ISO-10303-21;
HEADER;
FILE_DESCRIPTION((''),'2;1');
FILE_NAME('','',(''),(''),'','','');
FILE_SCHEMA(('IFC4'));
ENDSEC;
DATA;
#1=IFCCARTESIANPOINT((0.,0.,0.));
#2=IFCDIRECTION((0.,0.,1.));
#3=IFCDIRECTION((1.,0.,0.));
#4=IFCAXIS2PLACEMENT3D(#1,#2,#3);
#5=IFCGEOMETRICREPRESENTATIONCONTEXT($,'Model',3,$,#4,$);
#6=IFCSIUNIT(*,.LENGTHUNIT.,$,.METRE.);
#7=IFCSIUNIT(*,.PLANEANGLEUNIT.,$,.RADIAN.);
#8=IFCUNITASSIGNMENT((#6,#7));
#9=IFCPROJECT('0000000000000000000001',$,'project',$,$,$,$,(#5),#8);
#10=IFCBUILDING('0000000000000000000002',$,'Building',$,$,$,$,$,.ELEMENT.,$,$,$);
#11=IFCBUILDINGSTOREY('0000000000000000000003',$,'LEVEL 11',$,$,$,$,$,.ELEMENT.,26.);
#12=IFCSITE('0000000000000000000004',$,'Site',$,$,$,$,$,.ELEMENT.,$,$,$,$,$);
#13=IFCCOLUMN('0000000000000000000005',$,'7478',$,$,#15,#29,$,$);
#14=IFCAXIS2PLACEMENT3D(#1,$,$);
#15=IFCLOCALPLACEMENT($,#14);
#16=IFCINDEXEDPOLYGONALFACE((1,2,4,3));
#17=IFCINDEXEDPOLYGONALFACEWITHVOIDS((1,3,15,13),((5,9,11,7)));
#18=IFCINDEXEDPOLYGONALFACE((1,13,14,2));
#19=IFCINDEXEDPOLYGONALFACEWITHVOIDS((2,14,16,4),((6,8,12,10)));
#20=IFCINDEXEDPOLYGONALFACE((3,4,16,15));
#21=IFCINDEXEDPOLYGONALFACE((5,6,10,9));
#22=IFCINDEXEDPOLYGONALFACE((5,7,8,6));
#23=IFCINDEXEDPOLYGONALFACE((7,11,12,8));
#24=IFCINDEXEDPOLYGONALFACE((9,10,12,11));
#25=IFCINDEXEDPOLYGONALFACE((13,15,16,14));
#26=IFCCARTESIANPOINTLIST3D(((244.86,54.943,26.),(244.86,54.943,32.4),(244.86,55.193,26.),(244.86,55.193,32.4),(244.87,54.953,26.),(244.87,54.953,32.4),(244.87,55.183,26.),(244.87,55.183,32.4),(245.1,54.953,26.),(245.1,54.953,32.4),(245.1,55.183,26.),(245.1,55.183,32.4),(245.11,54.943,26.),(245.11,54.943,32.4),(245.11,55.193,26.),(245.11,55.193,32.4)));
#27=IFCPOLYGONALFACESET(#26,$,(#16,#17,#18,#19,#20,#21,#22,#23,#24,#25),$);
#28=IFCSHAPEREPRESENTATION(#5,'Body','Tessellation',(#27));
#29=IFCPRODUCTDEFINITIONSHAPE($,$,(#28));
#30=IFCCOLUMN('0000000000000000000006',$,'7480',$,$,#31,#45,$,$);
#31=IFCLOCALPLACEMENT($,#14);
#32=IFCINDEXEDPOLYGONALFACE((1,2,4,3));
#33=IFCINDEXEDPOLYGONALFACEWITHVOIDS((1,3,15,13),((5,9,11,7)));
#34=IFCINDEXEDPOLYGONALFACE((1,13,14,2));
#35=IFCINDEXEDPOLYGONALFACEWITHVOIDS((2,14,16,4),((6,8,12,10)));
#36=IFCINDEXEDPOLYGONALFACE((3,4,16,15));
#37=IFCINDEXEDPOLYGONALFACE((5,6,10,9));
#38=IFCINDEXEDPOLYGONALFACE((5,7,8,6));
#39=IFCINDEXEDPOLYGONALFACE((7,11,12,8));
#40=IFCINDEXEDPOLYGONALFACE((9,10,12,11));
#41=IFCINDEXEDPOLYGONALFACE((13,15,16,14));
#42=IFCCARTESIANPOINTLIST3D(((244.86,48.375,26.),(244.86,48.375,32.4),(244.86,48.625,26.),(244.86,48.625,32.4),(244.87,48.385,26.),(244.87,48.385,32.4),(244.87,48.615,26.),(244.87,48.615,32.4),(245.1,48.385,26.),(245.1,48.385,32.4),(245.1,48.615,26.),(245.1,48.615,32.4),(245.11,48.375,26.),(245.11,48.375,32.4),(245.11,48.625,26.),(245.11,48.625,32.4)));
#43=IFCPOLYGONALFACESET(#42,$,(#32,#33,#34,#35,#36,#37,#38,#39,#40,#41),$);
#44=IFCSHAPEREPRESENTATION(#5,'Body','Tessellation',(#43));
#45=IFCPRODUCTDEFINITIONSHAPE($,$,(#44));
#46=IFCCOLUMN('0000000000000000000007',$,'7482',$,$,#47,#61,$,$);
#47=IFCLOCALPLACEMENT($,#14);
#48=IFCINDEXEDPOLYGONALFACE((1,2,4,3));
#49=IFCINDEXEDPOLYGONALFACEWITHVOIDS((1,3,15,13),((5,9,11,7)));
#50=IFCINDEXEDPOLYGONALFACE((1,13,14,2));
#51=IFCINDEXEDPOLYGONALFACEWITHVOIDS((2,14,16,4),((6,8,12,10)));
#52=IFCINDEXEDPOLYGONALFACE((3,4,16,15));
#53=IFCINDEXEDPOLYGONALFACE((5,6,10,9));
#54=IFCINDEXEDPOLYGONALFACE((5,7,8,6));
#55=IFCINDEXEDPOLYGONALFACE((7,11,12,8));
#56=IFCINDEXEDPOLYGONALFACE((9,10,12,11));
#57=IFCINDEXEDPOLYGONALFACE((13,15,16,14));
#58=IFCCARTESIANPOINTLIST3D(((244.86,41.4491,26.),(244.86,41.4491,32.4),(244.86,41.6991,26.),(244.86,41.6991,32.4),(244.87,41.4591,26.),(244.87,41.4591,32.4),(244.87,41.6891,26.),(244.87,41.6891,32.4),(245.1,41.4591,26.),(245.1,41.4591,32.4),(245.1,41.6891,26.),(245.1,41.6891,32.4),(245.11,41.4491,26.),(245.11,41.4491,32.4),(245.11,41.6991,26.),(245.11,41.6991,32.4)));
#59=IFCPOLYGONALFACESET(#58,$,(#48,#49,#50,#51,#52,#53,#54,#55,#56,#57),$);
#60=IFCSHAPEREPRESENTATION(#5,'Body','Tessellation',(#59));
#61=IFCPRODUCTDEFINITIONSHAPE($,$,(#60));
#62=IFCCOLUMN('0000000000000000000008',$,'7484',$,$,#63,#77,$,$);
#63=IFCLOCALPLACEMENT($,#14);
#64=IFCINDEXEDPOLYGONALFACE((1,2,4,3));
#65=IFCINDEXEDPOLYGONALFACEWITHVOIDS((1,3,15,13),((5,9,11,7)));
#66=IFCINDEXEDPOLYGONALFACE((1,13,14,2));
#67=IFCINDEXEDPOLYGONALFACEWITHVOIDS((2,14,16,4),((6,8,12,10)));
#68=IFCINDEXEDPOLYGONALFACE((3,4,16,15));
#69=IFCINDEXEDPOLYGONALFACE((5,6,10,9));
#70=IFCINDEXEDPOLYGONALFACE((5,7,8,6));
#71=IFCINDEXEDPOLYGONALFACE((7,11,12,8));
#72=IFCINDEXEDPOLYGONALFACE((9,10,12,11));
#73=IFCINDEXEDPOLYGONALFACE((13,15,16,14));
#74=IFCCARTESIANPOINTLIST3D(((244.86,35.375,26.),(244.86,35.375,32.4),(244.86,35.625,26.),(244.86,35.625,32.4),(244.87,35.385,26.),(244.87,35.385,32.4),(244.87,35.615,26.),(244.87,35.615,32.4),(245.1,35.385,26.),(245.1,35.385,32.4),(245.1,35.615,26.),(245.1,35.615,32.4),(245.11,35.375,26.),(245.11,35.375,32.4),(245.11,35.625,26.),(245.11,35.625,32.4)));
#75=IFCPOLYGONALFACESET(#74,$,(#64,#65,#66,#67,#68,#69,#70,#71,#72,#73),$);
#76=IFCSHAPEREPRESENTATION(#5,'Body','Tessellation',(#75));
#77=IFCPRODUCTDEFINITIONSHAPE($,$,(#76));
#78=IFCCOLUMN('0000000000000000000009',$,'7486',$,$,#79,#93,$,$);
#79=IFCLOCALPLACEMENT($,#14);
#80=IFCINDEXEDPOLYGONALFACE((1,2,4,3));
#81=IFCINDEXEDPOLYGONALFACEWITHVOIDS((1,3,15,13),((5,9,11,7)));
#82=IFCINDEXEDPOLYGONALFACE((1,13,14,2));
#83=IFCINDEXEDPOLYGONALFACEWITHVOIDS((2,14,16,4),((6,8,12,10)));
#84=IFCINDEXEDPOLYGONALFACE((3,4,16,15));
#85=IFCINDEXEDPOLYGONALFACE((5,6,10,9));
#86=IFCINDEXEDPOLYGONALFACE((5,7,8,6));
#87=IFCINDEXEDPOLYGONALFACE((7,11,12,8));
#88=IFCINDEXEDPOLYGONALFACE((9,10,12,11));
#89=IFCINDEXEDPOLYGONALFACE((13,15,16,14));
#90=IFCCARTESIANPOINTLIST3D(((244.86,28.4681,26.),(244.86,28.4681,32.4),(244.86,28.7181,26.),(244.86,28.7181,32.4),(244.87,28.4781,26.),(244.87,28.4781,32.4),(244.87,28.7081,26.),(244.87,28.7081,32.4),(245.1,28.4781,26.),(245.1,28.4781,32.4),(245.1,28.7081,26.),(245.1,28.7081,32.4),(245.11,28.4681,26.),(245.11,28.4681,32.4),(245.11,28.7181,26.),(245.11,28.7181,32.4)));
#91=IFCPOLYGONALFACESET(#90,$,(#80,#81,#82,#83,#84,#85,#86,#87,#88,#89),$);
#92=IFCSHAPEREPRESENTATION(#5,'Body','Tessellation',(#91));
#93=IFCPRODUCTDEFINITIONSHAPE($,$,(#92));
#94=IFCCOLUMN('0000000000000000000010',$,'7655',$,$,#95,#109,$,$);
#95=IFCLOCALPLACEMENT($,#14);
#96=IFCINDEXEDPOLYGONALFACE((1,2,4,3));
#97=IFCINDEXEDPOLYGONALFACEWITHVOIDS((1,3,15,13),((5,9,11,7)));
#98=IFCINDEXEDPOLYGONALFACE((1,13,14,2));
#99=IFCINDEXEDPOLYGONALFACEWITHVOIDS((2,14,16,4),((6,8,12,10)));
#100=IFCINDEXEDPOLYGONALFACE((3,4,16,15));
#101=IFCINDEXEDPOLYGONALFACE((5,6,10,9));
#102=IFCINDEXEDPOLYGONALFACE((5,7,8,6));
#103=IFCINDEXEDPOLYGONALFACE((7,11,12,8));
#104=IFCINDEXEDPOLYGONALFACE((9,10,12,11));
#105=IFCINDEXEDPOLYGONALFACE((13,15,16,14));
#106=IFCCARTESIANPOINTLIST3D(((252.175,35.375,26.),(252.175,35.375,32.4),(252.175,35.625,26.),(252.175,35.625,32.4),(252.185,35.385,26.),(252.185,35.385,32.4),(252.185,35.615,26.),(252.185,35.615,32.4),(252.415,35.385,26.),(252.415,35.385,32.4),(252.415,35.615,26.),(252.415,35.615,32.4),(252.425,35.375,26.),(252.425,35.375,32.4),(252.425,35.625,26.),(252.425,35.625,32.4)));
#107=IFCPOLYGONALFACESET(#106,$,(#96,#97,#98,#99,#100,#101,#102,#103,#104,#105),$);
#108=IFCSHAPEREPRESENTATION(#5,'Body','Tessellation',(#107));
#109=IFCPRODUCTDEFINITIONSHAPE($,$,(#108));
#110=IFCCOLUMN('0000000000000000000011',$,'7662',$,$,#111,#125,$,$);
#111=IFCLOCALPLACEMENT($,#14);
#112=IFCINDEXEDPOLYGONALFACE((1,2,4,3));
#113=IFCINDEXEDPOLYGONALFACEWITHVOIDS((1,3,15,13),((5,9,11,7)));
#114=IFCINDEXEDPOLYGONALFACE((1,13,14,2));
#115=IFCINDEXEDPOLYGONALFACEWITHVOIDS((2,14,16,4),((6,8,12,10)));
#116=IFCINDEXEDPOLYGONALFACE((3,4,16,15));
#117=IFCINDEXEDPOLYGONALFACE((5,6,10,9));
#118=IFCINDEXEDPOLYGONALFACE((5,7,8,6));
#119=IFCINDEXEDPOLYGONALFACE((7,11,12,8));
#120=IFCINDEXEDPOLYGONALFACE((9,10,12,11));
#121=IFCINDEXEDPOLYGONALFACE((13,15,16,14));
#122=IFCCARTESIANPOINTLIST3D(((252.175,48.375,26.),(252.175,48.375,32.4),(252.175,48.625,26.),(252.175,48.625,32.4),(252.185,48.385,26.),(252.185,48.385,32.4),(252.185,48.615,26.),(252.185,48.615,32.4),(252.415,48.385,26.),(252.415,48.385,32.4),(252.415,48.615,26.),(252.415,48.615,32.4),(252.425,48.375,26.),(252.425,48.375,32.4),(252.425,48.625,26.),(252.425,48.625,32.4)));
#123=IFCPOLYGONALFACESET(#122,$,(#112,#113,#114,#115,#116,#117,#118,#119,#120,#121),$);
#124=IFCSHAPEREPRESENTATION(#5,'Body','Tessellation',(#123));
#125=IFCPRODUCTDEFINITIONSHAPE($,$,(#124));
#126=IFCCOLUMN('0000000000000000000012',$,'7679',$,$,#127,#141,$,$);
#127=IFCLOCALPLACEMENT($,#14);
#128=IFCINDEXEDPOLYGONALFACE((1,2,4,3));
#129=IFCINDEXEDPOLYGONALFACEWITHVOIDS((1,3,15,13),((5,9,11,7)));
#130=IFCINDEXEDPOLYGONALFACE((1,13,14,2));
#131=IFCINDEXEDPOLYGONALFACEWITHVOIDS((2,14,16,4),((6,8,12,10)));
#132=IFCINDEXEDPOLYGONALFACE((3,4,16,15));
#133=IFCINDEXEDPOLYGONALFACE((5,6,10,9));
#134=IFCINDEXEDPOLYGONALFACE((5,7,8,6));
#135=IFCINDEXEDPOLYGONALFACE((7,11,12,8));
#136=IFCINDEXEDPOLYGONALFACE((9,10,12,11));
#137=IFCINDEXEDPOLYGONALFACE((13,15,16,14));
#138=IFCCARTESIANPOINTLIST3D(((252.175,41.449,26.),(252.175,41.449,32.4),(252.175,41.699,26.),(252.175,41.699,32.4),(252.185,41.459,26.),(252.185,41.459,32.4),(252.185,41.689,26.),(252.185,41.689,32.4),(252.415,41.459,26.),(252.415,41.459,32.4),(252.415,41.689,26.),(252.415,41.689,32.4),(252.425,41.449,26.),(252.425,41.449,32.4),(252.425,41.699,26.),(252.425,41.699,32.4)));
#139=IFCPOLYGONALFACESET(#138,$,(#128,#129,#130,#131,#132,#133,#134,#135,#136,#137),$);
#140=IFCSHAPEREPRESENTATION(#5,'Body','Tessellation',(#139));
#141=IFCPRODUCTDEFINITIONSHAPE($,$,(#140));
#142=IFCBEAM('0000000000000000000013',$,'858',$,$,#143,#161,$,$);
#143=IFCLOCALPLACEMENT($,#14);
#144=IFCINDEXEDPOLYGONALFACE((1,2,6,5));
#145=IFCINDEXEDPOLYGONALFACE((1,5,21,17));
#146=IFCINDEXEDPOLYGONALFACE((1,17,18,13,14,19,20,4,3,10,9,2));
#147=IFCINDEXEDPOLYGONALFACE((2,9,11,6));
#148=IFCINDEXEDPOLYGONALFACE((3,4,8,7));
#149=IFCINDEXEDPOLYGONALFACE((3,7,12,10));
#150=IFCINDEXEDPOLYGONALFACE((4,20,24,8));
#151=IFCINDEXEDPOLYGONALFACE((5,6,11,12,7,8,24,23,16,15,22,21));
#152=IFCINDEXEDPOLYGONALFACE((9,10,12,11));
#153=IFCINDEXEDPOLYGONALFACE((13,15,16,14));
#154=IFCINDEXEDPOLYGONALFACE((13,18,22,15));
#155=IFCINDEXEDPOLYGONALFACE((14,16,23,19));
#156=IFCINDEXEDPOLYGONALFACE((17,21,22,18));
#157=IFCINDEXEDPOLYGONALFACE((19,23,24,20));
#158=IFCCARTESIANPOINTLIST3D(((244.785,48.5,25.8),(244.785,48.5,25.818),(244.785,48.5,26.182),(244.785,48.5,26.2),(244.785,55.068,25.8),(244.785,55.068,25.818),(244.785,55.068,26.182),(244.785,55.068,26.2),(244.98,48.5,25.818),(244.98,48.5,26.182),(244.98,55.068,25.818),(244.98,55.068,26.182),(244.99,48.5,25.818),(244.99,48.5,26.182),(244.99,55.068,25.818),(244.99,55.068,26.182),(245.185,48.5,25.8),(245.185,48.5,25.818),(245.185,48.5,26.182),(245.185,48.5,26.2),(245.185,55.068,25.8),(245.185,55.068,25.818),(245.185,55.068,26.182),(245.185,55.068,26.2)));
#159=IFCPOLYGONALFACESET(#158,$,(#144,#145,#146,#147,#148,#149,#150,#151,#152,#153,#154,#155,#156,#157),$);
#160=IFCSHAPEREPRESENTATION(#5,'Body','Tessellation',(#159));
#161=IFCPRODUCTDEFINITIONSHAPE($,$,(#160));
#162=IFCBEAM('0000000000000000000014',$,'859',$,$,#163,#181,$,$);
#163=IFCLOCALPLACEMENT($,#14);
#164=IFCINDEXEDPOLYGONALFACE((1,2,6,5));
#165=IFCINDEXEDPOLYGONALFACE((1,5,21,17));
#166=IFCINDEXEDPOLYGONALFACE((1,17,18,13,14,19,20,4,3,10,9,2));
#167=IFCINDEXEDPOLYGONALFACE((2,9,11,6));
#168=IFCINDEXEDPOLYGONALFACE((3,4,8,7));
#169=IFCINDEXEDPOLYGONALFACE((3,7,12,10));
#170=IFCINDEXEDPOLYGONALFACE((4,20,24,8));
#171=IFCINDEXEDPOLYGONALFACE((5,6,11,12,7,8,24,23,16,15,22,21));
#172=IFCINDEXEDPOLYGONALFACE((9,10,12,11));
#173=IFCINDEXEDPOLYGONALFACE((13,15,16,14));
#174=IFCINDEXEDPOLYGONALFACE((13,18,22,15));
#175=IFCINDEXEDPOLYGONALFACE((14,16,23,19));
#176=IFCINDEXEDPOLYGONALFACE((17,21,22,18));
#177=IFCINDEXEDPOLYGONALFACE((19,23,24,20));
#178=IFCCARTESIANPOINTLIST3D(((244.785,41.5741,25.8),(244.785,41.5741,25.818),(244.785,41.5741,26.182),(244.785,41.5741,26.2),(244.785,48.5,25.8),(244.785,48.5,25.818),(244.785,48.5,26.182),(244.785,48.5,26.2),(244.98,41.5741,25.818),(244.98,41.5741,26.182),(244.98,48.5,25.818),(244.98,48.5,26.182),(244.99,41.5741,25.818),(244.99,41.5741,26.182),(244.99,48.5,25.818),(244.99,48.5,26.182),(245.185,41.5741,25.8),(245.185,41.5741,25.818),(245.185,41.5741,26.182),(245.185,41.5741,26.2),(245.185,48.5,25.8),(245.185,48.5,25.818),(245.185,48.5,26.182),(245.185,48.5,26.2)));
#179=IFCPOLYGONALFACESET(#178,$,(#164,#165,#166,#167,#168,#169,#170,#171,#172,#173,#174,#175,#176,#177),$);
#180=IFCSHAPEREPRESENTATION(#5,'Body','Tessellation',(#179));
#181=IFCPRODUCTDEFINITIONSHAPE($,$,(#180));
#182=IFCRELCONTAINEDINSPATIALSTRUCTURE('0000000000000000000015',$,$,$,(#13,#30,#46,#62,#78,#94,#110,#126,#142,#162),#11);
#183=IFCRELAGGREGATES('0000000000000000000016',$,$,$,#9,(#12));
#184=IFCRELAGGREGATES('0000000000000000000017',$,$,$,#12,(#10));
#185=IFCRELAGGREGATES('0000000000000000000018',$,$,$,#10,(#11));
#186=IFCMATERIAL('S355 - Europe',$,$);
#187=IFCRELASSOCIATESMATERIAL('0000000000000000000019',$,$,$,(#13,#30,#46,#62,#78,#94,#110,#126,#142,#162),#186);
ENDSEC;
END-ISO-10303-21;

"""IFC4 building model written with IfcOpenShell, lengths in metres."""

from ifc_helpers import new_model, si_unit, frame, origin_with_axes, origin_2d_with_axis, place, context, project, spatial, hollow_rectangle, i_section, extrude, material, material_profile, profile_set, profile_usage, element, save


model = new_model("IFC4")

# Units and contexts
model_context = context("Model", 3, world=origin_with_axes())
ifc_project = project(units=[si_unit("LENGTHUNIT", "METRE"), si_unit("PLANEANGLEUNIT", "RADIAN")], contexts=[model_context])

# Site, building, storey
site = spatial("IfcSite", under=ifc_project, Name="Site", CompositionType="ELEMENT")
building = spatial("IfcBuilding", under=site, Name="Building", CompositionType="ELEMENT")
storey = spatial("IfcBuildingStorey", under=building, Name="LEVEL 11", CompositionType="ELEMENT", Elevation=26.0)

# Columns
ifc_material = material(Name="S355 - Europe")
ifc_material_profile_1 = material_profile(ifc_material, hollow_rectangle(XDim=0.25, YDim=0.25, WallThickness=0.01, at=origin_2d_with_axis()))
ifc_profile_set_1 = profile_set([ifc_material_profile_1])
ifc_profile_usage_1 = profile_usage(ifc_profile_set_1, cardinal=10)
column_1_placement = place(None, frame((244.985, 55.068, 26.0), z_axis=(0.0, 0.0, 1.0), x_axis=(0.0, -1.0, 0.0)))
element("IfcColumn", 1, at=column_1_placement, inside=storey, material=ifc_profile_usage_1, Name="7478", context=model_context, shape_type="SweptSolid", body=[
    extrude(hollow_rectangle(XDim=0.25, YDim=0.25, WallThickness=0.01, at=origin_2d_with_axis()), origin_with_axes(), (0.0, 0.0, 1.0), 6.4),
])
ifc_material_profile_2 = material_profile(ifc_material, hollow_rectangle(XDim=0.25, YDim=0.25, WallThickness=0.01, at=origin_2d_with_axis()))
ifc_profile_set_2 = profile_set([ifc_material_profile_2])
ifc_profile_usage_2 = profile_usage(ifc_profile_set_2, cardinal=10)
column_2_placement = place(None, frame((244.985, 48.5, 26.0), z_axis=(0.0, 0.0, 1.0), x_axis=(0.0, -1.0, 0.0)))
element("IfcColumn", 2, at=column_2_placement, inside=storey, material=ifc_profile_usage_2, Name="7480", context=model_context, shape_type="SweptSolid", body=[
    extrude(hollow_rectangle(XDim=0.25, YDim=0.25, WallThickness=0.01, at=origin_2d_with_axis()), origin_with_axes(), (0.0, 0.0, 1.0), 6.4),
])
ifc_material_profile_3 = material_profile(ifc_material, hollow_rectangle(XDim=0.25, YDim=0.25, WallThickness=0.01, at=origin_2d_with_axis()))
ifc_profile_set_3 = profile_set([ifc_material_profile_3])
ifc_profile_usage_3 = profile_usage(ifc_profile_set_3, cardinal=10)
column_3_placement = place(None, frame((244.985, 41.5741, 26.0), z_axis=(0.0, 0.0, 1.0), x_axis=(0.0, -1.0, 0.0)))
element("IfcColumn", 3, at=column_3_placement, inside=storey, material=ifc_profile_usage_3, Name="7482", context=model_context, shape_type="SweptSolid", body=[
    extrude(hollow_rectangle(XDim=0.25, YDim=0.25, WallThickness=0.01, at=origin_2d_with_axis()), origin_with_axes(), (0.0, 0.0, 1.0), 6.4),
])
ifc_material_profile_4 = material_profile(ifc_material, hollow_rectangle(XDim=0.25, YDim=0.25, WallThickness=0.01, at=origin_2d_with_axis()))
ifc_profile_set_4 = profile_set([ifc_material_profile_4])
ifc_profile_usage_4 = profile_usage(ifc_profile_set_4, cardinal=10)
column_4_placement = place(None, frame((244.985, 35.5, 26.0), z_axis=(0.0, 0.0, 1.0), x_axis=(0.0, -1.0, 0.0)))
element("IfcColumn", 4, at=column_4_placement, inside=storey, material=ifc_profile_usage_4, Name="7484", context=model_context, shape_type="SweptSolid", body=[
    extrude(hollow_rectangle(XDim=0.25, YDim=0.25, WallThickness=0.01, at=origin_2d_with_axis()), origin_with_axes(), (0.0, 0.0, 1.0), 6.4),
])
ifc_material_profile_5 = material_profile(ifc_material, hollow_rectangle(XDim=0.25, YDim=0.25, WallThickness=0.01, at=origin_2d_with_axis()))
ifc_profile_set_5 = profile_set([ifc_material_profile_5])
ifc_profile_usage_5 = profile_usage(ifc_profile_set_5, cardinal=10)
column_5_placement = place(None, frame((244.985, 28.5931, 26.0), z_axis=(0.0, 0.0, 1.0), x_axis=(0.0, -1.0, 0.0)))
element("IfcColumn", 5, at=column_5_placement, inside=storey, material=ifc_profile_usage_5, Name="7486", context=model_context, shape_type="SweptSolid", body=[
    extrude(hollow_rectangle(XDim=0.25, YDim=0.25, WallThickness=0.01, at=origin_2d_with_axis()), origin_with_axes(), (0.0, 0.0, 1.0), 6.4),
])
ifc_material_profile_6 = material_profile(ifc_material, hollow_rectangle(XDim=0.25, YDim=0.25, WallThickness=0.01, at=origin_2d_with_axis()))
ifc_profile_set_6 = profile_set([ifc_material_profile_6])
ifc_profile_usage_6 = profile_usage(ifc_profile_set_6, cardinal=10)
column_6_placement = place(None, frame((252.3, 35.5, 26.0), z_axis=(0.0, 0.0, 1.0), x_axis=(0.0, -1.0, 0.0)))
element("IfcColumn", 6, at=column_6_placement, inside=storey, material=ifc_profile_usage_6, Name="7655", context=model_context, shape_type="SweptSolid", body=[
    extrude(hollow_rectangle(XDim=0.25, YDim=0.25, WallThickness=0.01, at=origin_2d_with_axis()), origin_with_axes(), (0.0, 0.0, 1.0), 6.4),
])
ifc_material_profile_7 = material_profile(ifc_material, hollow_rectangle(XDim=0.25, YDim=0.25, WallThickness=0.01, at=origin_2d_with_axis()))
ifc_profile_set_7 = profile_set([ifc_material_profile_7])
ifc_profile_usage_7 = profile_usage(ifc_profile_set_7, cardinal=10)
column_7_placement = place(None, frame((252.3, 48.5, 26.0), z_axis=(0.0, 0.0, 1.0), x_axis=(0.0, -1.0, 0.0)))
element("IfcColumn", 7, at=column_7_placement, inside=storey, material=ifc_profile_usage_7, Name="7662", context=model_context, shape_type="SweptSolid", body=[
    extrude(hollow_rectangle(XDim=0.25, YDim=0.25, WallThickness=0.01, at=origin_2d_with_axis()), origin_with_axes(), (0.0, 0.0, 1.0), 6.4),
])
ifc_material_profile_8 = material_profile(ifc_material, hollow_rectangle(XDim=0.25, YDim=0.25, WallThickness=0.01, at=origin_2d_with_axis()))
ifc_profile_set_8 = profile_set([ifc_material_profile_8])
ifc_profile_usage_8 = profile_usage(ifc_profile_set_8, cardinal=10)
column_8_placement = place(None, frame((252.3, 41.574, 26.0), z_axis=(0.0, 0.0, 1.0), x_axis=(0.0, -1.0, 0.0)))
element("IfcColumn", 8, at=column_8_placement, inside=storey, material=ifc_profile_usage_8, Name="7679", context=model_context, shape_type="SweptSolid", body=[
    extrude(hollow_rectangle(XDim=0.25, YDim=0.25, WallThickness=0.01, at=origin_2d_with_axis()), origin_with_axes(), (0.0, 0.0, 1.0), 6.4),
])

# Beams
ifc_material_profile_9 = material_profile(ifc_material, i_section(OverallWidth=0.4, OverallDepth=0.4, WebThickness=0.01, FlangeThickness=0.018, at=origin_2d_with_axis()))
ifc_profile_set_9 = profile_set([ifc_material_profile_9])
ifc_profile_usage_9 = profile_usage(ifc_profile_set_9, cardinal=10)
beam_1_placement = place(None, frame((244.985, 55.068, 26.0), z_axis=(0.0, -1.0, 0.0), x_axis=(1.0, 0.0, 0.0)))
element("IfcBeam", 9, at=beam_1_placement, inside=storey, material=ifc_profile_usage_9, Name="858", context=model_context, shape_type="SweptSolid", body=[
    extrude(i_section(OverallWidth=0.4, OverallDepth=0.4, WebThickness=0.01, FlangeThickness=0.018, at=origin_2d_with_axis()), origin_with_axes(), (0.0, 0.0, 1.0), 6.568),
])
ifc_material_profile_10 = material_profile(ifc_material, i_section(OverallWidth=0.4, OverallDepth=0.4, WebThickness=0.01, FlangeThickness=0.018, at=origin_2d_with_axis()))
ifc_profile_set_10 = profile_set([ifc_material_profile_10])
ifc_profile_usage_10 = profile_usage(ifc_profile_set_10, cardinal=10)
beam_2_placement = place(None, frame((244.985, 48.5, 26.0), z_axis=(0.0, -1.0, 0.0), x_axis=(1.0, 0.0, 0.0)))
element("IfcBeam", 10, at=beam_2_placement, inside=storey, material=ifc_profile_usage_10, Name="859", context=model_context, shape_type="SweptSolid", body=[
    extrude(i_section(OverallWidth=0.4, OverallDepth=0.4, WebThickness=0.01, FlangeThickness=0.018, at=origin_2d_with_axis()), origin_with_axes(), (0.0, 0.0, 1.0), 6.9259),
])

save(model, "model.ifc")
